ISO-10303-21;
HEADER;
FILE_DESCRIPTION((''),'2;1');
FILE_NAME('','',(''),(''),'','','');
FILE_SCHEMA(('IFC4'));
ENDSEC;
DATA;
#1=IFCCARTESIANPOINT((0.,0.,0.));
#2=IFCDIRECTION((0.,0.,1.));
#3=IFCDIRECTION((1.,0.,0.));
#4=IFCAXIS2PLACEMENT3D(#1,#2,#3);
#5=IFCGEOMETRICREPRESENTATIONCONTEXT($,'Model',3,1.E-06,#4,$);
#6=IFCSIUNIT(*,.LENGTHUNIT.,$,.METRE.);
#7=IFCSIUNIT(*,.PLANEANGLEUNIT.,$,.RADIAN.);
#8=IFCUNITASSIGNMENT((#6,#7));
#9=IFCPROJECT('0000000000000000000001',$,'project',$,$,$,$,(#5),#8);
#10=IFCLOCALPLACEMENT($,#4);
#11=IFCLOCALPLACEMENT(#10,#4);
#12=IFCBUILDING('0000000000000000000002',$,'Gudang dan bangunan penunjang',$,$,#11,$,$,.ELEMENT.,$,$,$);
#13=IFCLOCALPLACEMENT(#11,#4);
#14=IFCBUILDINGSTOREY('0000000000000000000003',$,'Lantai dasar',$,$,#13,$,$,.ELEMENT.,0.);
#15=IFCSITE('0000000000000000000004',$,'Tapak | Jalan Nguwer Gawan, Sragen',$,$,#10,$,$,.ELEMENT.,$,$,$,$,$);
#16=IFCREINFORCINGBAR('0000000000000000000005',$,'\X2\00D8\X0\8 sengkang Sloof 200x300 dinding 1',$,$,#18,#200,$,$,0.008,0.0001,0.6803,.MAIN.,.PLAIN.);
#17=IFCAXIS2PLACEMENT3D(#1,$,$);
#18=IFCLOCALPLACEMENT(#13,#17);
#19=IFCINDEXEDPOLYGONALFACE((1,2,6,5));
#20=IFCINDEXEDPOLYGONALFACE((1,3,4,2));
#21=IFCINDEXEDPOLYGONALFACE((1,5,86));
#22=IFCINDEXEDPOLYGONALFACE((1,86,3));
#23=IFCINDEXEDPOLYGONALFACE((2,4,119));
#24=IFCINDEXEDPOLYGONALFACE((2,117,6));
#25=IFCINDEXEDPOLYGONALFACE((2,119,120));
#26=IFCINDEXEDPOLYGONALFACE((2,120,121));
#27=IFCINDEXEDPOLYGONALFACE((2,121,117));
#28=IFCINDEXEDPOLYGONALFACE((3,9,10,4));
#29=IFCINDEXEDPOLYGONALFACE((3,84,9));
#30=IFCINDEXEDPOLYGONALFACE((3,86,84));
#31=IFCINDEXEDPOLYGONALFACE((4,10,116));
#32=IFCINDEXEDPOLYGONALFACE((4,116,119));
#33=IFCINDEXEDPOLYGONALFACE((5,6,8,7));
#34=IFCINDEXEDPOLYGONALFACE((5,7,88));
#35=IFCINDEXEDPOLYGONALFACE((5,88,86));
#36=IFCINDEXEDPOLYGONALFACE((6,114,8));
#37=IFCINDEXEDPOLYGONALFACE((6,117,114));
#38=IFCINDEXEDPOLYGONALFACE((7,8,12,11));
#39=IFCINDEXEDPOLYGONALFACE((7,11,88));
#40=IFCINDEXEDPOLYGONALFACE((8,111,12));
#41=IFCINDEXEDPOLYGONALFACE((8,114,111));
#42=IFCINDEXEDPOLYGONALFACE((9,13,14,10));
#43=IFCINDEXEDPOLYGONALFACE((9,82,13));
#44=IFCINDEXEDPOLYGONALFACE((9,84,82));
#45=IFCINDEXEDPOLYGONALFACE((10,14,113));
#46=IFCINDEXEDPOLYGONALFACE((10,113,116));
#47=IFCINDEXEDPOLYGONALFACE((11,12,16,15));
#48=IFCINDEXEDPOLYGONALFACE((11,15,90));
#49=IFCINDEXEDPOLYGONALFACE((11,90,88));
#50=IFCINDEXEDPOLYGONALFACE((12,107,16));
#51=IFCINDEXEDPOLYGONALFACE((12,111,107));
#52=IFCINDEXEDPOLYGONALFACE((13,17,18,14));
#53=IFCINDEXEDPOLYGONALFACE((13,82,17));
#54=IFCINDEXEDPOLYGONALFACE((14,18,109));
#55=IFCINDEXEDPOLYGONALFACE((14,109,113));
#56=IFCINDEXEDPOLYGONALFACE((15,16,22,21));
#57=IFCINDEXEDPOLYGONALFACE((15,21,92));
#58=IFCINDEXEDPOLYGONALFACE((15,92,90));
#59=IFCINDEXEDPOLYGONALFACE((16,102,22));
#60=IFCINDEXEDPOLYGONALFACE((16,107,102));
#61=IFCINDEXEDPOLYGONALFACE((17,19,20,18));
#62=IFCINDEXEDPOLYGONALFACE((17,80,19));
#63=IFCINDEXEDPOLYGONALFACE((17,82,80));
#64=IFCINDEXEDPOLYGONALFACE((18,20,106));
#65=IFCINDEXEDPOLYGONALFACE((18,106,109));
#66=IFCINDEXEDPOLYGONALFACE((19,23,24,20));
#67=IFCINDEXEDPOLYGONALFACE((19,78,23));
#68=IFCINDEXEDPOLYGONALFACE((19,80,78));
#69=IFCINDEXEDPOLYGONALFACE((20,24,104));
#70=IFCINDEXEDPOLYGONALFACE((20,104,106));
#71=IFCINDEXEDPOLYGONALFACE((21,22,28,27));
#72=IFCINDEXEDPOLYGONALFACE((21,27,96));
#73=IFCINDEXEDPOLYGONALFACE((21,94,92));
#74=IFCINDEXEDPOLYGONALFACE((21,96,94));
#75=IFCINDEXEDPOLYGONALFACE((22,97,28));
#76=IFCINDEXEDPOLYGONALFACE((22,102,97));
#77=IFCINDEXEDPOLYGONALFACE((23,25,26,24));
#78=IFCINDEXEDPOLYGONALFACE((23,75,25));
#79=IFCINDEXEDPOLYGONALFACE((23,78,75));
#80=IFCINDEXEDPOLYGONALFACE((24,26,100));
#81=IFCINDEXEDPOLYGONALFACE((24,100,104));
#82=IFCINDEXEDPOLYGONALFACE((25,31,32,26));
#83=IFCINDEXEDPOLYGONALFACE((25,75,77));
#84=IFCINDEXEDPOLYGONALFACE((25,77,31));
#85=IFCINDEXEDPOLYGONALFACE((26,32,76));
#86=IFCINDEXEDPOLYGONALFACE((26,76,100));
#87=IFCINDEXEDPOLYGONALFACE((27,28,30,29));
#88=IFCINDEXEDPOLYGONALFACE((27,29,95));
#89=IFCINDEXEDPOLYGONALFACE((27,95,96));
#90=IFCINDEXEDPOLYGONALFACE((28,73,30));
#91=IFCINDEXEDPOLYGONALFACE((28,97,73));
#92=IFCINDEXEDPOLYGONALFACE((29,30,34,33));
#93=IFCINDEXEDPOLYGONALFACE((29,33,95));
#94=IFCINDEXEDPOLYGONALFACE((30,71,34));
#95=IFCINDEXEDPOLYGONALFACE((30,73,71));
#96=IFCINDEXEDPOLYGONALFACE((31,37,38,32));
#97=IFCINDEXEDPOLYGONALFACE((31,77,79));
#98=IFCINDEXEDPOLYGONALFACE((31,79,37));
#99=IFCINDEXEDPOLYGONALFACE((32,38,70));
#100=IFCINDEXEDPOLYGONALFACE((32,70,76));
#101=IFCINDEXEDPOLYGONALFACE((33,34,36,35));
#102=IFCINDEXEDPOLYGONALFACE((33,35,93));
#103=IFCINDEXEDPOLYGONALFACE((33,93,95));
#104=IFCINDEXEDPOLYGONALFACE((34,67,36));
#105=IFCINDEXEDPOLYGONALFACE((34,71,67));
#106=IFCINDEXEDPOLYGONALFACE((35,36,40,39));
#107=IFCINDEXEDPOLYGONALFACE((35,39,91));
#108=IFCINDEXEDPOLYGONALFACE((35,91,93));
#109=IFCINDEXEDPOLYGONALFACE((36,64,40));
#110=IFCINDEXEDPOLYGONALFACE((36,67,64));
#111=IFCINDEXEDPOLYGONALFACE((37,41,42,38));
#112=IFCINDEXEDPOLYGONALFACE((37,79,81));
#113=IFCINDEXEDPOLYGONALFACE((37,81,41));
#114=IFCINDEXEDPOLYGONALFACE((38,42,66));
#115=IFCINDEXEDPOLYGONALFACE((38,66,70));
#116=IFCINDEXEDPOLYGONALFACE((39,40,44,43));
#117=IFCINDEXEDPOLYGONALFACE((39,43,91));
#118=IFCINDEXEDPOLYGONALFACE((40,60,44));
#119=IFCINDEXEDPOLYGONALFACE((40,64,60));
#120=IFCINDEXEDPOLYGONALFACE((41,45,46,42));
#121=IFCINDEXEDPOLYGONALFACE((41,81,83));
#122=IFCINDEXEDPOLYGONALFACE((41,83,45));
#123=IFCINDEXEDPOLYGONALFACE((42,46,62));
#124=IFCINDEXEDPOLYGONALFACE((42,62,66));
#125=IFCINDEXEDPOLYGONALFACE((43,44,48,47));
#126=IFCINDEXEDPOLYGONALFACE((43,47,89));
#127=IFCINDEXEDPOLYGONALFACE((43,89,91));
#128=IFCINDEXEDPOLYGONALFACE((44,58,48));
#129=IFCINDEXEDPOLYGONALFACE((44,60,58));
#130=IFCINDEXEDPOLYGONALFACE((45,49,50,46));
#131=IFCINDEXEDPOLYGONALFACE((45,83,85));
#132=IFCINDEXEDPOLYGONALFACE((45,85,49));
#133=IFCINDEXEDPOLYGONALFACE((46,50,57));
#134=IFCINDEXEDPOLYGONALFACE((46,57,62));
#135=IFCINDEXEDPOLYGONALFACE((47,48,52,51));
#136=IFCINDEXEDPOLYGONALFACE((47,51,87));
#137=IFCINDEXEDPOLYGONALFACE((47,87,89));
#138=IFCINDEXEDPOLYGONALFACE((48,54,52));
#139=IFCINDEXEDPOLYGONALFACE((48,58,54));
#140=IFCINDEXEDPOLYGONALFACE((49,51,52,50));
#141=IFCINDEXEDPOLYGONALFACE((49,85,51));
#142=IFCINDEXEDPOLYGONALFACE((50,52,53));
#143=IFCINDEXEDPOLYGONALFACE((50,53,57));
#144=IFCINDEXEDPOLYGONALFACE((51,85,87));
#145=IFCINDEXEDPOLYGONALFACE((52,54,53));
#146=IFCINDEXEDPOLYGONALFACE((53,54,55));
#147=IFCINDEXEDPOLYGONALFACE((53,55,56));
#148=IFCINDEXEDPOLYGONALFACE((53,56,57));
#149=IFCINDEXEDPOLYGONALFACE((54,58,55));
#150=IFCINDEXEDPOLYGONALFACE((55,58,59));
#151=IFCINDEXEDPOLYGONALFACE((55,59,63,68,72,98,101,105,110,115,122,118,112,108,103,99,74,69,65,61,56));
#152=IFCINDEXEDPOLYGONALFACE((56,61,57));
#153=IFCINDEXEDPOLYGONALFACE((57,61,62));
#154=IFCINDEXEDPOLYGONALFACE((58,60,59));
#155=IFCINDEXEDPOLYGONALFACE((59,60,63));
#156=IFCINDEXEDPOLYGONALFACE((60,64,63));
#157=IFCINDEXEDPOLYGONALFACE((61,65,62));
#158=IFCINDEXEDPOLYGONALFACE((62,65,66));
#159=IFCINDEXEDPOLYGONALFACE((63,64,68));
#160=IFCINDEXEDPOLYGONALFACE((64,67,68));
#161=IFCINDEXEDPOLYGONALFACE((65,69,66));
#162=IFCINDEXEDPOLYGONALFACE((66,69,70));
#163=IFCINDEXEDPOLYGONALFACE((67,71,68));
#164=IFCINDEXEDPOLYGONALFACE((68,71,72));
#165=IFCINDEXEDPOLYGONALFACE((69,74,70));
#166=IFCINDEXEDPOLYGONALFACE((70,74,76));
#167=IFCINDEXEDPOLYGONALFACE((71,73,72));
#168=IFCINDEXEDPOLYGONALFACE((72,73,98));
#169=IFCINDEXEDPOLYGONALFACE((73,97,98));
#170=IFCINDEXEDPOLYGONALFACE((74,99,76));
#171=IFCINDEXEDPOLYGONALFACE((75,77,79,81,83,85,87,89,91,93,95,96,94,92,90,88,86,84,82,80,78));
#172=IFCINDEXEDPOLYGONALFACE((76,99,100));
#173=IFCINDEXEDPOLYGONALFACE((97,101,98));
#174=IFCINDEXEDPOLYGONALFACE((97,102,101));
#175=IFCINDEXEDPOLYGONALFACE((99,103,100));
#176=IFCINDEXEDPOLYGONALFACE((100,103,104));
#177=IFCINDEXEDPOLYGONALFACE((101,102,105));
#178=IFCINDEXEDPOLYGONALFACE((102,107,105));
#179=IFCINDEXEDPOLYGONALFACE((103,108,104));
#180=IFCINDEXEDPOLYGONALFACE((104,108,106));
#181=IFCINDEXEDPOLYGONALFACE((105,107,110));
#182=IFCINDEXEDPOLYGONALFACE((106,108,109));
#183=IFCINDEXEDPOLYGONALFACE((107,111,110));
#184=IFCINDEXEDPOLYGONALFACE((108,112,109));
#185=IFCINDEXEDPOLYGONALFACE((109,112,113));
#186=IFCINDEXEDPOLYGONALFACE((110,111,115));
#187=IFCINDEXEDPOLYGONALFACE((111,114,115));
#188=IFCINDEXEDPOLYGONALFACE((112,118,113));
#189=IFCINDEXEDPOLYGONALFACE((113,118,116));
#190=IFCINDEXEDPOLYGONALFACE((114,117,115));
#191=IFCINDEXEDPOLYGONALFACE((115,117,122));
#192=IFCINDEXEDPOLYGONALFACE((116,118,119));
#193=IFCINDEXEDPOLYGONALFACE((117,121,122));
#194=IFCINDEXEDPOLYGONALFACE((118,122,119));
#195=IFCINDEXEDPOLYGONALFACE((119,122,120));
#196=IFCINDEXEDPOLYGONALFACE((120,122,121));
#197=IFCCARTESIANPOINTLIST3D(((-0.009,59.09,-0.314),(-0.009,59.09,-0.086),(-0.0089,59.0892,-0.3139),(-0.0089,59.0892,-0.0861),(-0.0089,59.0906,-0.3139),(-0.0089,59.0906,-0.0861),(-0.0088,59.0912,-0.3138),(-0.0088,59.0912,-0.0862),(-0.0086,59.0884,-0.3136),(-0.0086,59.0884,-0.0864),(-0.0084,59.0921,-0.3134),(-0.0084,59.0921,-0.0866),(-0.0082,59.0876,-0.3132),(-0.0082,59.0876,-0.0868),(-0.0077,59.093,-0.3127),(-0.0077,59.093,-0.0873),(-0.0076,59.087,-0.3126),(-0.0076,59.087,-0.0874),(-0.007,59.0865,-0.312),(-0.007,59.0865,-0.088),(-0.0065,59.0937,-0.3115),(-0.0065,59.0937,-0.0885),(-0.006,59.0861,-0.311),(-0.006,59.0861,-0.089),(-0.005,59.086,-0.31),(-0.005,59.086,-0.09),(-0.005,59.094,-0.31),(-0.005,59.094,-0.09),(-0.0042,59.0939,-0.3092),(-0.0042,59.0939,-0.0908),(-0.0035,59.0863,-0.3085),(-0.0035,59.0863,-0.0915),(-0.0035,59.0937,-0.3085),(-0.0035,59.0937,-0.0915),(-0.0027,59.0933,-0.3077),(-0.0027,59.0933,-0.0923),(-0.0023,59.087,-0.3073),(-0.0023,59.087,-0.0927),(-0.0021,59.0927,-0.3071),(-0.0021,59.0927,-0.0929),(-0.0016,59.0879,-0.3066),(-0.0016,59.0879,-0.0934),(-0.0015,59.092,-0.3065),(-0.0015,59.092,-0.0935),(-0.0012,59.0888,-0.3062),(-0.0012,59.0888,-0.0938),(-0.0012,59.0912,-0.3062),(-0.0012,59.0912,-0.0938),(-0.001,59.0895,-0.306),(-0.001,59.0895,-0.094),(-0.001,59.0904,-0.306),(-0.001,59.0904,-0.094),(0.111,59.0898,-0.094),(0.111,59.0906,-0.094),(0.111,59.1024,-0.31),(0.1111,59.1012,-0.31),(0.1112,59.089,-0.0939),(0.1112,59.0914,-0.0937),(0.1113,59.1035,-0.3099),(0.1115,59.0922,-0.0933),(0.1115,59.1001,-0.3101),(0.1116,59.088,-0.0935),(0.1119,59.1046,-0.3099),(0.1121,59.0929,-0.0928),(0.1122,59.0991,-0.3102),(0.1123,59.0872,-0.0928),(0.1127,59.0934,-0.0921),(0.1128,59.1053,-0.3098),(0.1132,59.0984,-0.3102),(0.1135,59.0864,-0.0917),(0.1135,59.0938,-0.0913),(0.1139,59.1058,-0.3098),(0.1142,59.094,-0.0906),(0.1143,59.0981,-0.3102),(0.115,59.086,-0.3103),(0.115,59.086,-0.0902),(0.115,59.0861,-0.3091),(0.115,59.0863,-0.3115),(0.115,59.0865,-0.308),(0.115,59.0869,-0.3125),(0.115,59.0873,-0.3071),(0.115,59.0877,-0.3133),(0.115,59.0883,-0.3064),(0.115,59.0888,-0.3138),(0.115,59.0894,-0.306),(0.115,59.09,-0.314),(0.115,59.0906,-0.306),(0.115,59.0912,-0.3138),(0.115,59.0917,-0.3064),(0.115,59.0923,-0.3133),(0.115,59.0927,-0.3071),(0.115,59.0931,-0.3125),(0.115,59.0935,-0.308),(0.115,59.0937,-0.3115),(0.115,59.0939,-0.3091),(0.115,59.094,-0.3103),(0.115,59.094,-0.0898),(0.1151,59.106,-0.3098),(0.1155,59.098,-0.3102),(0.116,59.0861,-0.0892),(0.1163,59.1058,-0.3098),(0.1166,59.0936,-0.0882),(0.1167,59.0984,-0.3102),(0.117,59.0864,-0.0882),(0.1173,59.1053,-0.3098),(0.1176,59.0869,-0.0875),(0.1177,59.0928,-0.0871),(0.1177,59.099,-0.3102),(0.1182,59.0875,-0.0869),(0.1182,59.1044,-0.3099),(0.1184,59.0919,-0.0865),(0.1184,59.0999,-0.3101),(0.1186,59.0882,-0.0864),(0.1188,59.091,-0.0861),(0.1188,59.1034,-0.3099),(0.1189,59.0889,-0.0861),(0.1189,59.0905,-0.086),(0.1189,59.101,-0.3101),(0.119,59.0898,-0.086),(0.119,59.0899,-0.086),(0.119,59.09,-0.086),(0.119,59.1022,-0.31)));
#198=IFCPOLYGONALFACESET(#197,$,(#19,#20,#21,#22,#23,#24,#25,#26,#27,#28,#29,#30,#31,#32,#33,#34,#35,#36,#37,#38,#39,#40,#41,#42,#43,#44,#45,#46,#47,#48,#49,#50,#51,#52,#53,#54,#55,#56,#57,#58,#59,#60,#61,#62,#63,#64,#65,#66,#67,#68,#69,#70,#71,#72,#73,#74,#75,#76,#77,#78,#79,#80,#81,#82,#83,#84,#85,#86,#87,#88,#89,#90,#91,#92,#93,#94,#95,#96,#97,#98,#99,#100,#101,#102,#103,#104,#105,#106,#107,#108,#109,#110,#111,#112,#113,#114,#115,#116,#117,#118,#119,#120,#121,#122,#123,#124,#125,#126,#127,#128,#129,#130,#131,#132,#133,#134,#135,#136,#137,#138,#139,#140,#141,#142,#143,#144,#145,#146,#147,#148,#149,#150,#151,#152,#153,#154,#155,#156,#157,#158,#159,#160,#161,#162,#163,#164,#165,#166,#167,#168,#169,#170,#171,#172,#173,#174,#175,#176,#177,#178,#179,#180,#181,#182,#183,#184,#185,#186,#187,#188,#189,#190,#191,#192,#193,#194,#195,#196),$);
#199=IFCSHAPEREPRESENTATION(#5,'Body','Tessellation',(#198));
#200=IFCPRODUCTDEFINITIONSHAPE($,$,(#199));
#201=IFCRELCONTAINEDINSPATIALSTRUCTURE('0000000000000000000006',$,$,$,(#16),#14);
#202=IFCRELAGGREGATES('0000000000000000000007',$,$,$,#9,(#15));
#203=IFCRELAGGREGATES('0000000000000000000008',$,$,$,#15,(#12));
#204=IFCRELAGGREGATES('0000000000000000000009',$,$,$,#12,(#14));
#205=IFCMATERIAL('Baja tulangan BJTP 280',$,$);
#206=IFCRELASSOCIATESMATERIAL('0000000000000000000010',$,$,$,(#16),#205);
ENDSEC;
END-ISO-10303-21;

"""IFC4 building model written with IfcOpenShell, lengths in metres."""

from ifc_helpers import new_model, entity, si_unit, origin_with_axes, place, context, project, spatial, material, element, save


model = new_model("IFC4")

# Units and contexts
model_context = context("Model", 3, precision=1e-06, world=origin_with_axes())
ifc_project = project(units=[si_unit("LENGTHUNIT", "METRE"), si_unit("PLANEANGLEUNIT", "RADIAN")], contexts=[model_context])

# Site, building, storey
site_placement = place(None, origin_with_axes())
site = spatial("IfcSite", under=ifc_project, at=site_placement, Name="Tapak | Jalan Nguwer Gawan, Sragen", CompositionType="ELEMENT")
building_placement = place(site_placement, origin_with_axes())
building = spatial("IfcBuilding", under=site, at=building_placement, Name="Gudang dan bangunan penunjang", CompositionType="ELEMENT")
storey_placement = place(building_placement, origin_with_axes())
storey = spatial("IfcBuildingStorey", under=building, at=storey_placement, Name="Lantai dasar", CompositionType="ELEMENT", Elevation=0.0)

# Shared definitions
placement = place(None, origin_with_axes())

# Reinforcing bar
ifc_material_1 = material(Name="Baja tulangan BJTP 280")
element("IfcReinforcingBar", 1, at=placement, inside=storey, material=ifc_material_1, Name="Ø8 sengkang Sloof 200x300 dinding 1", BarLength=0.6803, BarSurface="PLAIN", CrossSectionArea=0.0001, NominalDiameter=0.008, PredefinedType="MAIN", context=model_context, shape_type="AdvancedSweptSolid", body=[
    entity("IfcSweptDiskSolid", entity("IfcPolyline", [entity("IfcCartesianPoint", [0.115, 59.09, -0.31]), entity("IfcCartesianPoint", [-0.005, 59.09, -0.31]), entity("IfcCartesianPoint", [-0.005, 59.09, -0.09]), entity("IfcCartesianPoint", [0.115, 59.09, -0.09]), entity("IfcCartesianPoint", [0.115, 59.102, -0.31])]), 0.004),
])

save(model, "model.ifc")
